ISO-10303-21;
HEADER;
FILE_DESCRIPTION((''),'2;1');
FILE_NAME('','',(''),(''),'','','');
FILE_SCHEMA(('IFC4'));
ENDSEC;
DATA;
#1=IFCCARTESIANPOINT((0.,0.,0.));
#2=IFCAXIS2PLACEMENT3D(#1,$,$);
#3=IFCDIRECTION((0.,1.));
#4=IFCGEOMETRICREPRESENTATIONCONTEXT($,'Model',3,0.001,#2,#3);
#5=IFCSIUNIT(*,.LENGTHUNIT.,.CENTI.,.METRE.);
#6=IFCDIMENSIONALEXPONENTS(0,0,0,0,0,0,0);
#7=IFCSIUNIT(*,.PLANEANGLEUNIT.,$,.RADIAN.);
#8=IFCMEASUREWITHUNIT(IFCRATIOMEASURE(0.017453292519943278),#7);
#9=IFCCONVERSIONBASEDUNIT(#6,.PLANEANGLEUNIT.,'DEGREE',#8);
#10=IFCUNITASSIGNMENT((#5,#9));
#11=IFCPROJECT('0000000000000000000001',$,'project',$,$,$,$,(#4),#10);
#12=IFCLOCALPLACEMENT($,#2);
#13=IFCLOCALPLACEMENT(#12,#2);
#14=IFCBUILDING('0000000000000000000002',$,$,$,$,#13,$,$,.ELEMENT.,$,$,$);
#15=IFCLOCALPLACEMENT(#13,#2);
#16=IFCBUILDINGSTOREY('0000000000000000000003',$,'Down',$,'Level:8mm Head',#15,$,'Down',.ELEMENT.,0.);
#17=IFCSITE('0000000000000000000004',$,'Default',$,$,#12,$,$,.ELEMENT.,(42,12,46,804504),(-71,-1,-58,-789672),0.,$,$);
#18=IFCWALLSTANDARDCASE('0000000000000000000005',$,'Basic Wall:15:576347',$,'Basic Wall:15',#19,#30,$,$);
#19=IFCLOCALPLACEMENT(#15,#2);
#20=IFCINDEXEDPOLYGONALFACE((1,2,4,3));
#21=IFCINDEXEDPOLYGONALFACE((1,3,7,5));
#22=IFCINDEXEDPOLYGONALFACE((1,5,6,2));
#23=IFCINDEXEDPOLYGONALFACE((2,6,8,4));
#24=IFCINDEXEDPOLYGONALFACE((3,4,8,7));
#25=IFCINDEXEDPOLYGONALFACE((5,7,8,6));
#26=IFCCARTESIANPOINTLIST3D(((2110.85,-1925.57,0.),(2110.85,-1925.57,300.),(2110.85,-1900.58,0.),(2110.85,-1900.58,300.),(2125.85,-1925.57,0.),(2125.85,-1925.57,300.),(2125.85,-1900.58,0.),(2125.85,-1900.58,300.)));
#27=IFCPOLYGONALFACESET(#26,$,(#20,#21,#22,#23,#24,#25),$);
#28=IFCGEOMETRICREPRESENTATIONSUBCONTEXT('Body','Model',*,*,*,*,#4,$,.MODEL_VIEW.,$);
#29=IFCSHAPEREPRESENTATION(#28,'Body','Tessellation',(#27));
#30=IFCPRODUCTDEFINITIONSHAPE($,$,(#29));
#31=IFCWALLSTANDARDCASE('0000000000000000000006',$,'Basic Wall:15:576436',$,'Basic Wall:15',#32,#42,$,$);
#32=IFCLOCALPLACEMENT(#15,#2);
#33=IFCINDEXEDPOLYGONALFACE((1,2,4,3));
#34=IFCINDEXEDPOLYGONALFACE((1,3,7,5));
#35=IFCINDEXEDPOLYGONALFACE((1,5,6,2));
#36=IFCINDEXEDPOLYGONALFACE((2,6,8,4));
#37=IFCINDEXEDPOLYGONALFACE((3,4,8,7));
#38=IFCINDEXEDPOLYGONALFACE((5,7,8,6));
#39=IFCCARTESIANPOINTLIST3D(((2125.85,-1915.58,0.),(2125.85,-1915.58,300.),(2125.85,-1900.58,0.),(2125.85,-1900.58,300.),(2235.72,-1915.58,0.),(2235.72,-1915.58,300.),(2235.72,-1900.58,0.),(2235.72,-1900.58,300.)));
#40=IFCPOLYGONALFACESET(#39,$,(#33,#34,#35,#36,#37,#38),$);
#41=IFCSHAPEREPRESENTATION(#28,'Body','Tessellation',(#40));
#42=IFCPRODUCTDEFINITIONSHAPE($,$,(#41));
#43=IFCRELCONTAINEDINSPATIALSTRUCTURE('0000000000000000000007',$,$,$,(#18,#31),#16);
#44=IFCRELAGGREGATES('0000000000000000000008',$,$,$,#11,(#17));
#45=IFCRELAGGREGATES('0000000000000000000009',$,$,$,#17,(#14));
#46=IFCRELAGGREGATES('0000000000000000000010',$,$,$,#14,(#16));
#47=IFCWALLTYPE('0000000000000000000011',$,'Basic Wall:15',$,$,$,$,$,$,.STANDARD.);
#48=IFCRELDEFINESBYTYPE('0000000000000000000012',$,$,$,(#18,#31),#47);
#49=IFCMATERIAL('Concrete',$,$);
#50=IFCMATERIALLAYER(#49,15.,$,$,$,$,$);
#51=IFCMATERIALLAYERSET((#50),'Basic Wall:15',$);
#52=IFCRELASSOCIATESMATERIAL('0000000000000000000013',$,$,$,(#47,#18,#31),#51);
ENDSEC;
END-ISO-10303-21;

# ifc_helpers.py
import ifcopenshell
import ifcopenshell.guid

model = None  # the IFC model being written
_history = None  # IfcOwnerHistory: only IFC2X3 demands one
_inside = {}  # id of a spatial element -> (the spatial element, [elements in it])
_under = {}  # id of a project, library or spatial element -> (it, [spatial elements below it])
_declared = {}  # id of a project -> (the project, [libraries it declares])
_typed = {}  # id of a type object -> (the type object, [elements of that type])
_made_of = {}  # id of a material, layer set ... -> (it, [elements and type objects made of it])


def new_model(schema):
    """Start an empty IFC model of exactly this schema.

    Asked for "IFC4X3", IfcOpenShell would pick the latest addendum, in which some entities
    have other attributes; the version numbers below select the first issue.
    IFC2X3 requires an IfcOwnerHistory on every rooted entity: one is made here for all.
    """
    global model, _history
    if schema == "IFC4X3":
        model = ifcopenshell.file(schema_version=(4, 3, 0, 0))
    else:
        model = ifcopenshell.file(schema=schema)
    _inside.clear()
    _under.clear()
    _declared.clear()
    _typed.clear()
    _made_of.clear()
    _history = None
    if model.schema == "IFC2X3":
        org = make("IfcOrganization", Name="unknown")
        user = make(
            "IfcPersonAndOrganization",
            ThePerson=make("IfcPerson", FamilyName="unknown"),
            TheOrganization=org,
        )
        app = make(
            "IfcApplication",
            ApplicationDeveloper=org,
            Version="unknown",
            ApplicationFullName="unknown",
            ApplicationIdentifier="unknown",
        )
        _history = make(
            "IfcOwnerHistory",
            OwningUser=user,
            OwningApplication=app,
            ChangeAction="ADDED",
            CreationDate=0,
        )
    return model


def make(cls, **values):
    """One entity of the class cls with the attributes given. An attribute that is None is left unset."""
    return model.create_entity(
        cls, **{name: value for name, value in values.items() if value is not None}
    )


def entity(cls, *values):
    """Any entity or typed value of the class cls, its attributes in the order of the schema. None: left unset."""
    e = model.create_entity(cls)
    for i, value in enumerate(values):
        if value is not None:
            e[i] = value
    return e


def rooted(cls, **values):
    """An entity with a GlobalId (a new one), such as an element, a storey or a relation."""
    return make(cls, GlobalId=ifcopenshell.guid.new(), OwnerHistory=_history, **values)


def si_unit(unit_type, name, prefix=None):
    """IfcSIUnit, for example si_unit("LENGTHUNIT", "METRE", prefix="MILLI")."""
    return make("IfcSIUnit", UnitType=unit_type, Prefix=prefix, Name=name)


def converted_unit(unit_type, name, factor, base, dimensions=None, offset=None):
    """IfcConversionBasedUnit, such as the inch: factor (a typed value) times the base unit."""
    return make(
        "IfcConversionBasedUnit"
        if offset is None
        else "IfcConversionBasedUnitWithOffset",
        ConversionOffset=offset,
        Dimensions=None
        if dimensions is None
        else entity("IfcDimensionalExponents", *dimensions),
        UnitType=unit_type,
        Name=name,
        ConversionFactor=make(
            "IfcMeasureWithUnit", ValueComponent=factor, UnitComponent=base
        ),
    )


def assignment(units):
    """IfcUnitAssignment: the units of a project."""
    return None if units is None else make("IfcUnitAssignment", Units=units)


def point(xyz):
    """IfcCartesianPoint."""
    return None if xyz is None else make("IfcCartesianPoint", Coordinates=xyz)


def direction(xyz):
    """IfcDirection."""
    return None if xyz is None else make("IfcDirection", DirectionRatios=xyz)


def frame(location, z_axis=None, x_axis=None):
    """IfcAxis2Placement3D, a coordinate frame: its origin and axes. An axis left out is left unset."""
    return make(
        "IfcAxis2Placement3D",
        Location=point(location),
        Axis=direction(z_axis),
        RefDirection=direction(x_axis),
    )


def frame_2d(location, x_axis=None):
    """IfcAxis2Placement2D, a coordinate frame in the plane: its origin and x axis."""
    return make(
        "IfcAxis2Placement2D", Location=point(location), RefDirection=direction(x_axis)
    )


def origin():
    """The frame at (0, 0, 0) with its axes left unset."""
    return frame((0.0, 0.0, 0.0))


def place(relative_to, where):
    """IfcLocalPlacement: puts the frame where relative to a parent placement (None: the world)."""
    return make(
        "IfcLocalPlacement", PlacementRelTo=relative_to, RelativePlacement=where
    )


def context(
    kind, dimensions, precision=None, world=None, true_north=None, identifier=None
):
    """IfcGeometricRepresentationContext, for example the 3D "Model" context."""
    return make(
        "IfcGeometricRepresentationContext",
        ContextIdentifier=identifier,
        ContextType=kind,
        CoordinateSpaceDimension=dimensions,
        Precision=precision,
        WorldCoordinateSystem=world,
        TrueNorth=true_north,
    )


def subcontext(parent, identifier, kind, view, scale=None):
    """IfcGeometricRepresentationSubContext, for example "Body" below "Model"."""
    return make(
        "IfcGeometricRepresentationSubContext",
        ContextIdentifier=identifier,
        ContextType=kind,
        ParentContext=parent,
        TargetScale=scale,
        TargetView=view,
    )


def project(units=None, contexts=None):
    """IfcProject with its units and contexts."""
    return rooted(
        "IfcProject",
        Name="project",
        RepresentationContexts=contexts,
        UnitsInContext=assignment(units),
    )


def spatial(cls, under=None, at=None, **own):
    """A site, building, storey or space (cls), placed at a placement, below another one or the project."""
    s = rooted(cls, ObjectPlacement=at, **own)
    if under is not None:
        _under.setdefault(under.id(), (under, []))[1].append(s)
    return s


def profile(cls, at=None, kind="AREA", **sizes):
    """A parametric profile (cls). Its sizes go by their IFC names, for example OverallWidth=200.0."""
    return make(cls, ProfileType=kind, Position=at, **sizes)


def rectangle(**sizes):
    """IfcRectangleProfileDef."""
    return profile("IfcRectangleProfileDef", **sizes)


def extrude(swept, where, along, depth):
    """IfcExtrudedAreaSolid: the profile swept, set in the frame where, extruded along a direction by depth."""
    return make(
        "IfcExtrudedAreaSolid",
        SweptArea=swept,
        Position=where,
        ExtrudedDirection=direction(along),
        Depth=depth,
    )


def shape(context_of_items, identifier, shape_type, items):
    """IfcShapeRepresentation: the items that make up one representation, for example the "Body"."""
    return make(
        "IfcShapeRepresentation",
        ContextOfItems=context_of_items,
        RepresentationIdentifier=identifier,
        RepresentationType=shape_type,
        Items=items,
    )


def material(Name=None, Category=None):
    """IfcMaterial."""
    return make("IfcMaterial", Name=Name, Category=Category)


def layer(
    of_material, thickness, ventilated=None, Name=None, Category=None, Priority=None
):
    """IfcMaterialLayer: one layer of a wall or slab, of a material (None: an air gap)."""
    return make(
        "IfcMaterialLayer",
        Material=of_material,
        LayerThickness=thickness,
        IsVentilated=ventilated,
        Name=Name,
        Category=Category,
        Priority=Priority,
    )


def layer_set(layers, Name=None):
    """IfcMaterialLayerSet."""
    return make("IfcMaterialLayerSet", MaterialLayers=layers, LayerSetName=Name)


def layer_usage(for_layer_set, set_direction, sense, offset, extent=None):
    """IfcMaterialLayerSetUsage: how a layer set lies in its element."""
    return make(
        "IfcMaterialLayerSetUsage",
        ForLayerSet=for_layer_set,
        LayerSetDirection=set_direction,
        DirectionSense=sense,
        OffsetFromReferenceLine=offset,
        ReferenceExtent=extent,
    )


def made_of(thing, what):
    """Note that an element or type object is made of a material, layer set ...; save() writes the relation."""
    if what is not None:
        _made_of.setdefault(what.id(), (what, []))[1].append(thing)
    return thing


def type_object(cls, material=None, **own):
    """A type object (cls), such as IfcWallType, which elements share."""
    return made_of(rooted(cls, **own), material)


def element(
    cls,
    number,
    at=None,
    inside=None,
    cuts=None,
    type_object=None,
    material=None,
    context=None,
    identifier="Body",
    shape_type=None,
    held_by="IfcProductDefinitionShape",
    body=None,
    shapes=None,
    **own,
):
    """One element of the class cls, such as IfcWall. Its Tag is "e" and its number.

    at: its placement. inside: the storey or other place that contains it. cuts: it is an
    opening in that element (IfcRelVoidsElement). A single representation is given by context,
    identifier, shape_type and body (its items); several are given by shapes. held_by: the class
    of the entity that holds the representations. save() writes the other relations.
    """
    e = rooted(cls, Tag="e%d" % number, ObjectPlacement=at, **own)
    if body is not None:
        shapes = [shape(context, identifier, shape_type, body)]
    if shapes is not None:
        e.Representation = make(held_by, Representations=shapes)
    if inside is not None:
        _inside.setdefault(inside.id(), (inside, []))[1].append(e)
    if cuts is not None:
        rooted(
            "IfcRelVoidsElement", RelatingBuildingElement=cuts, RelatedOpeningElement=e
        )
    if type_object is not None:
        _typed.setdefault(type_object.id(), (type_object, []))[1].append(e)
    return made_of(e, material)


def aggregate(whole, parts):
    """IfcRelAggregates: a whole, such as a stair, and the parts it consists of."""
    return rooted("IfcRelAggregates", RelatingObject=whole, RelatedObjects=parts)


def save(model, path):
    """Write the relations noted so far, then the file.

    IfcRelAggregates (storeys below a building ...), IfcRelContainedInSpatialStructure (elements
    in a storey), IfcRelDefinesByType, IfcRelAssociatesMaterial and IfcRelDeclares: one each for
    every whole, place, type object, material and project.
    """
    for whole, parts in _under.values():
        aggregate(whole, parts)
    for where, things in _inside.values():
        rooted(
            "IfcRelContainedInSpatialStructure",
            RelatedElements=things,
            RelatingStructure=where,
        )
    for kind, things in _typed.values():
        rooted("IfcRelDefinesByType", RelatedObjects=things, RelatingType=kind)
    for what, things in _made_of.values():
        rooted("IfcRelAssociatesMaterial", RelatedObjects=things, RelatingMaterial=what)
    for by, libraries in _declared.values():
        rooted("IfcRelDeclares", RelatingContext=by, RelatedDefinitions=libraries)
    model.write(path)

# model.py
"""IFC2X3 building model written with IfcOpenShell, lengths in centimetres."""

from ifc_helpers import new_model, entity, si_unit, converted_unit, direction, frame, frame_2d, origin, place, context, subcontext, project, spatial, rectangle, extrude, material, layer, layer_set, layer_usage, type_object, element, save


model = new_model("IFC2X3")

# Units and contexts
model_context = context("Model", 3, precision=0.001, world=origin(), true_north=direction((0.0, 1.0)))
body_context = subcontext(model_context, "Body", "Model", "MODEL_VIEW")
ifc_project = project(units=[si_unit("LENGTHUNIT", "METRE", prefix="CENTI"), converted_unit("PLANEANGLEUNIT", "DEGREE", entity("IfcRatioMeasure", 0.017453292519943278), si_unit("PLANEANGLEUNIT", "RADIAN"), dimensions=[0, 0, 0, 0, 0, 0, 0])], contexts=[model_context])

# Site, building, storey
site_placement = place(None, origin())
site = spatial("IfcSite", under=ifc_project, at=site_placement, Name="Default", CompositionType="ELEMENT", RefLatitude=(42, 12, 46, 804504), RefLongitude=(-71, -1, -58, -789672), RefElevation=0.0)
building_placement = place(site_placement, origin())
building = spatial("IfcBuilding", under=site, at=building_placement, CompositionType="ELEMENT")
storey_placement = place(building_placement, origin())
storey = spatial("IfcBuildingStorey", under=building, at=storey_placement, Name="Down", ObjectType="Level:8mm Head", LongName="Down", CompositionType="ELEMENT", Elevation=0.0)

# Walls
ifc_material = material(Name="Concrete")
ifc_layer_1 = layer(ifc_material, 15.0)
ifc_layer_set_1 = layer_set([ifc_layer_1], Name="Basic Wall:15")
wall_type_1 = type_object("IfcWallType", Name="Basic Wall:15", PredefinedType="STANDARD", material=ifc_layer_set_1)
ifc_layer_usage_1 = layer_usage(ifc_layer_set_1, "AXIS2", "NEGATIVE", 7.5)
wall_1_placement = place(storey_placement, frame((2118.35, -1925.57, 0.0), z_axis=(0.0, 0.0, 1.0), x_axis=(0.0, 1.0, 0.0)))
element("IfcWallStandardCase", 1, at=wall_1_placement, inside=storey, type_object=wall_type_1, material=ifc_layer_usage_1, Name="Basic Wall:15:576347", ObjectType="Basic Wall:15", context=body_context, shape_type="SweptSolid", body=[
    extrude(rectangle(XDim=24.99, YDim=15.0, at=frame_2d((12.5, 0.0), x_axis=(-1.0, 0.0))), origin(), (0.0, 0.0, 1.0), 300.0),
])
ifc_layer_usage_2 = layer_usage(ifc_layer_set_1, "AXIS2", "NEGATIVE", 7.5)
wall_2_placement = place(storey_placement, frame((2125.85, -1908.08, 0.0)))
element("IfcWallStandardCase", 2, at=wall_2_placement, inside=storey, type_object=wall_type_1, material=ifc_layer_usage_2, Name="Basic Wall:15:576436", ObjectType="Basic Wall:15", context=body_context, shape_type="SweptSolid", body=[
    extrude(rectangle(XDim=109.87, YDim=15.0, at=frame_2d((54.93, 0.0), x_axis=(-1.0, 0.0))), origin(), (0.0, 0.0, 1.0), 300.0),
])

save(model, "model.ifc")
